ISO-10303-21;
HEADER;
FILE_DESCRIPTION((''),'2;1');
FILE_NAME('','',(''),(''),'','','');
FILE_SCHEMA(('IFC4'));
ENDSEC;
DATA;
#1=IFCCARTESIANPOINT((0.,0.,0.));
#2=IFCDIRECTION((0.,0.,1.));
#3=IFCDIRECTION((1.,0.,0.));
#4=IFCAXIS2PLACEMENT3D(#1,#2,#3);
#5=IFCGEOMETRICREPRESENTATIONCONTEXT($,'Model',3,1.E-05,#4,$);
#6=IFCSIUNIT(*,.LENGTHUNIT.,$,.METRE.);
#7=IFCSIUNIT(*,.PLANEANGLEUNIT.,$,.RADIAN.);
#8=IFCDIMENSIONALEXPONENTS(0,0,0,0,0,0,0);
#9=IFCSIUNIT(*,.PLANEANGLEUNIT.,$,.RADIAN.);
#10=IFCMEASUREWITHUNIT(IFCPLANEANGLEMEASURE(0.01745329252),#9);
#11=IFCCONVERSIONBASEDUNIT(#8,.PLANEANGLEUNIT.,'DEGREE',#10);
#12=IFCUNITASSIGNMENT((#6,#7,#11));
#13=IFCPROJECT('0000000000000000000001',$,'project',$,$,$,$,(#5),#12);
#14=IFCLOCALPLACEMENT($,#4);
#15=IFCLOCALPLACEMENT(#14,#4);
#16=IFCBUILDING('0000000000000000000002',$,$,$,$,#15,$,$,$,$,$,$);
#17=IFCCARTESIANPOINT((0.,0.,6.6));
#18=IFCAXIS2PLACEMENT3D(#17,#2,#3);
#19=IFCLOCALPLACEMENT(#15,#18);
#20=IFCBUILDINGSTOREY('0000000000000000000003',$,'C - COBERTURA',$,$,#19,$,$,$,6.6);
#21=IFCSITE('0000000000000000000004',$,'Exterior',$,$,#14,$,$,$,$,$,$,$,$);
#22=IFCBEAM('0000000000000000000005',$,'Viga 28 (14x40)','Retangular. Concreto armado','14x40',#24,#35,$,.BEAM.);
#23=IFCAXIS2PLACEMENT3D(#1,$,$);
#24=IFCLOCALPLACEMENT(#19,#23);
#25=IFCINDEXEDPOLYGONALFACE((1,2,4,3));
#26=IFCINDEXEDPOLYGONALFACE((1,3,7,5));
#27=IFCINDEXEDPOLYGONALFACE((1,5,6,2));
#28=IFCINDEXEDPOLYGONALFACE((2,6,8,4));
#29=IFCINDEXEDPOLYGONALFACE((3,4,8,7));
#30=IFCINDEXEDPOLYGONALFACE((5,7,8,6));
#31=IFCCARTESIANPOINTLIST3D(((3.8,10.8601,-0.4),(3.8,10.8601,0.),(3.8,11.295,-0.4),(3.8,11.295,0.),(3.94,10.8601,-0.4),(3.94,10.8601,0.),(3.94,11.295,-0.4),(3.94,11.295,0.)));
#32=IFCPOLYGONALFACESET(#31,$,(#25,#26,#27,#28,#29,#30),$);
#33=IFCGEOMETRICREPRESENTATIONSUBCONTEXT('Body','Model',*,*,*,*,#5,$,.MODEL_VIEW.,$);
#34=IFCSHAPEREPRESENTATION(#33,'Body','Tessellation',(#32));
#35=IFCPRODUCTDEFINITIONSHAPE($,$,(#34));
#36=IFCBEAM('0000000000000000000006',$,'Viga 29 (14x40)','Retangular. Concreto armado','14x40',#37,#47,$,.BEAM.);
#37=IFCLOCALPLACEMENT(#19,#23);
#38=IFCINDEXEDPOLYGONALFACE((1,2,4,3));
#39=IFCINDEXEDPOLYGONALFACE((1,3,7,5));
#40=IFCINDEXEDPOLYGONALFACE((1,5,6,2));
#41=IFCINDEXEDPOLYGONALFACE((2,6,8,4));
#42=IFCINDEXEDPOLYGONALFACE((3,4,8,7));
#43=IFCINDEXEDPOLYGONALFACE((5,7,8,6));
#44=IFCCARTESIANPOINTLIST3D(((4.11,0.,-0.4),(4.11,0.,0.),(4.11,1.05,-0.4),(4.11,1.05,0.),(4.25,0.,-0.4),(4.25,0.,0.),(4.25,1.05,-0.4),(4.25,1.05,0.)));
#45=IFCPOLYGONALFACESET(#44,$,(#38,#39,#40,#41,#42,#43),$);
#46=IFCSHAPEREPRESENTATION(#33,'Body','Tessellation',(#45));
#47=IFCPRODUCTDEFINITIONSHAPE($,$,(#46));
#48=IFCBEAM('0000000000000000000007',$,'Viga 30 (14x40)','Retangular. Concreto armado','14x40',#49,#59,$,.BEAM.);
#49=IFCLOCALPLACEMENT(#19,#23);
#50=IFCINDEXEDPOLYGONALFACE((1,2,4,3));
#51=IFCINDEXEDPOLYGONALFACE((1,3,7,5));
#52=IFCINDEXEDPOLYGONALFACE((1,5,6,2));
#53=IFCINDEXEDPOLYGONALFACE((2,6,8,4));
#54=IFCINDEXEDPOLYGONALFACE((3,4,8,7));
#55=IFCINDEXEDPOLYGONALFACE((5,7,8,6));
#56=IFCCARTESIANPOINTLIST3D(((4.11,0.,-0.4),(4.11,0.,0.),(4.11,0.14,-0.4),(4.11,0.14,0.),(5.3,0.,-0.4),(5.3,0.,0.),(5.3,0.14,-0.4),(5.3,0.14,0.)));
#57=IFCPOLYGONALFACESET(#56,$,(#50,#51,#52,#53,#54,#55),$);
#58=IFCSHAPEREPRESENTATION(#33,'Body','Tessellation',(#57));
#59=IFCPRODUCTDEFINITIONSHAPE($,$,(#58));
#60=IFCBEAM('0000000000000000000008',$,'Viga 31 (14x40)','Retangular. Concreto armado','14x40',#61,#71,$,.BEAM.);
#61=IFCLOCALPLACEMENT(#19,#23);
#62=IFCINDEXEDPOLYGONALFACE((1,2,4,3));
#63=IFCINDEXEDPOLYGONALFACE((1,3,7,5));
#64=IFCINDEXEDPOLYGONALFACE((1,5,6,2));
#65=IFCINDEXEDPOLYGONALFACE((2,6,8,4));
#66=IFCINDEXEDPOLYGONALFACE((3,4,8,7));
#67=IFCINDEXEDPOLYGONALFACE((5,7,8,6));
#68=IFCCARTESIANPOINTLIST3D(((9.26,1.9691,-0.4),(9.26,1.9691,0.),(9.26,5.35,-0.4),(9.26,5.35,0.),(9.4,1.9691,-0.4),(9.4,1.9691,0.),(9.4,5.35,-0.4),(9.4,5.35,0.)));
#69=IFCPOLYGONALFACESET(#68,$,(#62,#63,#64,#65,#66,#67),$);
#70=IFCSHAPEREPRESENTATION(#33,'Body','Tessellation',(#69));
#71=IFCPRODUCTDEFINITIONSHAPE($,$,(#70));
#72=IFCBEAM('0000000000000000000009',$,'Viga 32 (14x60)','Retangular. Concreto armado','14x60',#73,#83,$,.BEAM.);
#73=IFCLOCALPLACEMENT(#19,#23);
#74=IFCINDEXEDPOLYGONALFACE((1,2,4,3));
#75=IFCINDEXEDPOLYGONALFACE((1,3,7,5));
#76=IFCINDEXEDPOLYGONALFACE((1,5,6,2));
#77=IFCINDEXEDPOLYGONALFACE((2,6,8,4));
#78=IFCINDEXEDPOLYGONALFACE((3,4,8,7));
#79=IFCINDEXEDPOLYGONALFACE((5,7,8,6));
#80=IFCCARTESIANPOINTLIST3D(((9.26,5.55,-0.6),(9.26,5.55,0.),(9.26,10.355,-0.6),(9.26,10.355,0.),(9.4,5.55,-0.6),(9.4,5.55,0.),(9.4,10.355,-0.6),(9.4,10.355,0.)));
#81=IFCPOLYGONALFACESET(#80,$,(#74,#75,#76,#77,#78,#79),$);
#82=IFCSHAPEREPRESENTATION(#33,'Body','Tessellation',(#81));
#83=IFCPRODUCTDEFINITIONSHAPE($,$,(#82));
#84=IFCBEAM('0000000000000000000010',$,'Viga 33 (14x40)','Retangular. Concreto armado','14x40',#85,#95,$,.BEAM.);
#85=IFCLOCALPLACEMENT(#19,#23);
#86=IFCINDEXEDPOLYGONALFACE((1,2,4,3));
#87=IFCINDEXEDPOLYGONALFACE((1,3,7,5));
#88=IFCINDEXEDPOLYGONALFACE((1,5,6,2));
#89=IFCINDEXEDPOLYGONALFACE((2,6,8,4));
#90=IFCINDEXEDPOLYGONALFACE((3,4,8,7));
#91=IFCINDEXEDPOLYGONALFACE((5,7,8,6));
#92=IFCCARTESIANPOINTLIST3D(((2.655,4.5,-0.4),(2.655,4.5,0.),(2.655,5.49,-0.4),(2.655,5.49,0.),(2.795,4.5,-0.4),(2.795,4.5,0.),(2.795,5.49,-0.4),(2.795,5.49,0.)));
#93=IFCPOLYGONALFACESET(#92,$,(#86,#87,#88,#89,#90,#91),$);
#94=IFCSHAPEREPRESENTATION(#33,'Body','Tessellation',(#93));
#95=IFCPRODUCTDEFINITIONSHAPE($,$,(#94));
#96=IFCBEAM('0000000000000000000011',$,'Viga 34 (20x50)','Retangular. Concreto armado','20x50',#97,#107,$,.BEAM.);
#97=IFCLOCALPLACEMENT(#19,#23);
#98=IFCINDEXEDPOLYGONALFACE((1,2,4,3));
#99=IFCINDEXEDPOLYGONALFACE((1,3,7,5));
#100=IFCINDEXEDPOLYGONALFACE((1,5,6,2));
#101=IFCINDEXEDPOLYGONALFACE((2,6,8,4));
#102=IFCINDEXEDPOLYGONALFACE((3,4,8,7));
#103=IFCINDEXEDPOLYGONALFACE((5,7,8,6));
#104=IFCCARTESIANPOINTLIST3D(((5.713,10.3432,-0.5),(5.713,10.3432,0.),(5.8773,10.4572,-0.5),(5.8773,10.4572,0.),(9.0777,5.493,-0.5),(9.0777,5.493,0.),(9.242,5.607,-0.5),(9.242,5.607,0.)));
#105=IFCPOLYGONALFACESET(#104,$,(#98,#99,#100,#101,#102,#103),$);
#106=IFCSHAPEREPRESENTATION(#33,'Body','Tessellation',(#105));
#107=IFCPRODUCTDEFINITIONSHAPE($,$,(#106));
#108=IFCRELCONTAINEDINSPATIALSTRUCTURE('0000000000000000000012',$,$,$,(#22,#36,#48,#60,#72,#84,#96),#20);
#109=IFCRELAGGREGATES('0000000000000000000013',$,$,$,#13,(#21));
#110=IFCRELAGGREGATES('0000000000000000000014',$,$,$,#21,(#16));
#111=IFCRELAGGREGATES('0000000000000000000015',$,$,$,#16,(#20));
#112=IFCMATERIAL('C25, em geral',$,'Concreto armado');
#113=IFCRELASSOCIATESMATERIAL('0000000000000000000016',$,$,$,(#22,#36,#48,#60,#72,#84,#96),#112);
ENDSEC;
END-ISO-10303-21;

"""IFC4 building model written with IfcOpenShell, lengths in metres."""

from ifc_helpers import new_model, entity, si_unit, converted_unit, frame, frame_2d, origin_with_axes, place, context, subcontext, project, spatial, rectangle, extrude, material, element, save


model = new_model("IFC4")

# Units and contexts
model_context = context("Model", 3, precision=1e-05, world=origin_with_axes())
body_context = subcontext(model_context, "Body", "Model", "MODEL_VIEW")
ifc_project = project(units=[si_unit("LENGTHUNIT", "METRE"), si_unit("PLANEANGLEUNIT", "RADIAN"), converted_unit("PLANEANGLEUNIT", "DEGREE", entity("IfcPlaneAngleMeasure", 0.01745329252), si_unit("PLANEANGLEUNIT", "RADIAN"), dimensions=[0, 0, 0, 0, 0, 0, 0])], contexts=[model_context])

# Site, building, storey
site_placement = place(None, origin_with_axes())
site = spatial("IfcSite", under=ifc_project, at=site_placement, Name="Exterior")
building_placement = place(site_placement, origin_with_axes())
building = spatial("IfcBuilding", under=site, at=building_placement)
storey_placement = place(building_placement, frame((0.0, 0.0, 6.6), z_axis=(0.0, 0.0, 1.0), x_axis=(1.0, 0.0, 0.0)))
storey = spatial("IfcBuildingStorey", under=building, at=storey_placement, Name="C - COBERTURA", Elevation=6.6)

# Shared definitions
ifc_material = material(Name="C25, em geral", Category="Concreto armado")

# Beams
beam_1_placement = place(storey_placement, frame((3.87, 10.8601, 0.0), z_axis=(0.0, 1.0, 0.0), x_axis=(-1.0, 0.0, 0.0)))
element("IfcBeam", 1, at=beam_1_placement, inside=storey, material=ifc_material, Name="Viga 28 (14x40)", Description="Retangular. Concreto armado", ObjectType="14x40", PredefinedType="BEAM", context=body_context, shape_type="SweptSolid", body=[
    extrude(rectangle(XDim=0.14, YDim=0.4, at=frame_2d((0.0, -0.2), x_axis=(1.0, 0.0))), origin_with_axes(), (0.0, 0.0, 1.0), 0.4349),
])
beam_2_placement = place(storey_placement, frame((4.18, 0.0, 0.0), z_axis=(0.0, 1.0, 0.0), x_axis=(-1.0, 0.0, 0.0)))
element("IfcBeam", 2, at=beam_2_placement, inside=storey, material=ifc_material, Name="Viga 29 (14x40)", Description="Retangular. Concreto armado", ObjectType="14x40", PredefinedType="BEAM", context=body_context, shape_type="SweptSolid", body=[
    extrude(rectangle(XDim=0.14, YDim=0.4, at=frame_2d((0.0, -0.2), x_axis=(1.0, 0.0))), origin_with_axes(), (0.0, 0.0, 1.0), 1.05),
])
beam_3_placement = place(storey_placement, frame((4.11, 0.07, 0.0), z_axis=(1.0, 0.0, 0.0), x_axis=(0.0, 1.0, 0.0)))
element("IfcBeam", 3, at=beam_3_placement, inside=storey, material=ifc_material, Name="Viga 30 (14x40)", Description="Retangular. Concreto armado", ObjectType="14x40", PredefinedType="BEAM", context=body_context, shape_type="SweptSolid", body=[
    extrude(rectangle(XDim=0.14, YDim=0.4, at=frame_2d((0.0, -0.2), x_axis=(1.0, 0.0))), origin_with_axes(), (0.0, 0.0, 1.0), 1.19),
])
beam_4_placement = place(storey_placement, frame((9.33, 1.9691, 0.0), z_axis=(0.0, 1.0, 0.0), x_axis=(-1.0, 0.0, 0.0)))
element("IfcBeam", 4, at=beam_4_placement, inside=storey, material=ifc_material, Name="Viga 31 (14x40)", Description="Retangular. Concreto armado", ObjectType="14x40", PredefinedType="BEAM", context=body_context, shape_type="SweptSolid", body=[
    extrude(rectangle(XDim=0.14, YDim=0.4, at=frame_2d((0.0, -0.2), x_axis=(1.0, 0.0))), origin_with_axes(), (0.0, 0.0, 1.0), 3.3809),
])
beam_5_placement = place(storey_placement, frame((9.33, 5.55, 0.0), z_axis=(0.0, 1.0, 0.0), x_axis=(-1.0, 0.0, 0.0)))
element("IfcBeam", 5, at=beam_5_placement, inside=storey, material=ifc_material, Name="Viga 32 (14x60)", Description="Retangular. Concreto armado", ObjectType="14x60", PredefinedType="BEAM", context=body_context, shape_type="SweptSolid", body=[
    extrude(rectangle(XDim=0.14, YDim=0.6, at=frame_2d((0.0, -0.3), x_axis=(1.0, 0.0))), origin_with_axes(), (0.0, 0.0, 1.0), 4.805),
])
beam_6_placement = place(storey_placement, frame((2.725, 4.5, 0.0), z_axis=(0.0, 1.0, 0.0), x_axis=(-1.0, 0.0, 0.0)))
element("IfcBeam", 6, at=beam_6_placement, inside=storey, material=ifc_material, Name="Viga 33 (14x40)", Description="Retangular. Concreto armado", ObjectType="14x40", PredefinedType="BEAM", context=body_context, shape_type="SweptSolid", body=[
    extrude(rectangle(XDim=0.14, YDim=0.4, at=frame_2d((0.0, -0.2), x_axis=(1.0, 0.0))), origin_with_axes(), (0.0, 0.0, 1.0), 0.99),
])
beam_7_placement = place(storey_placement, frame((9.1598, 5.55, 0.0), z_axis=(-0.56999, 0.821652, 0.0), x_axis=(-0.821652, -0.56999, 0.0)))
element("IfcBeam", 7, at=beam_7_placement, inside=storey, material=ifc_material, Name="Viga 34 (20x50)", Description="Retangular. Concreto armado", ObjectType="20x50", PredefinedType="BEAM", context=body_context, shape_type="SweptSolid", body=[
    extrude(rectangle(XDim=0.2, YDim=0.5, at=frame_2d((0.0, -0.25), x_axis=(1.0, 0.0))), origin_with_axes(), (0.0, 0.0, 1.0), 5.903),
])

save(model, "model.ifc")
